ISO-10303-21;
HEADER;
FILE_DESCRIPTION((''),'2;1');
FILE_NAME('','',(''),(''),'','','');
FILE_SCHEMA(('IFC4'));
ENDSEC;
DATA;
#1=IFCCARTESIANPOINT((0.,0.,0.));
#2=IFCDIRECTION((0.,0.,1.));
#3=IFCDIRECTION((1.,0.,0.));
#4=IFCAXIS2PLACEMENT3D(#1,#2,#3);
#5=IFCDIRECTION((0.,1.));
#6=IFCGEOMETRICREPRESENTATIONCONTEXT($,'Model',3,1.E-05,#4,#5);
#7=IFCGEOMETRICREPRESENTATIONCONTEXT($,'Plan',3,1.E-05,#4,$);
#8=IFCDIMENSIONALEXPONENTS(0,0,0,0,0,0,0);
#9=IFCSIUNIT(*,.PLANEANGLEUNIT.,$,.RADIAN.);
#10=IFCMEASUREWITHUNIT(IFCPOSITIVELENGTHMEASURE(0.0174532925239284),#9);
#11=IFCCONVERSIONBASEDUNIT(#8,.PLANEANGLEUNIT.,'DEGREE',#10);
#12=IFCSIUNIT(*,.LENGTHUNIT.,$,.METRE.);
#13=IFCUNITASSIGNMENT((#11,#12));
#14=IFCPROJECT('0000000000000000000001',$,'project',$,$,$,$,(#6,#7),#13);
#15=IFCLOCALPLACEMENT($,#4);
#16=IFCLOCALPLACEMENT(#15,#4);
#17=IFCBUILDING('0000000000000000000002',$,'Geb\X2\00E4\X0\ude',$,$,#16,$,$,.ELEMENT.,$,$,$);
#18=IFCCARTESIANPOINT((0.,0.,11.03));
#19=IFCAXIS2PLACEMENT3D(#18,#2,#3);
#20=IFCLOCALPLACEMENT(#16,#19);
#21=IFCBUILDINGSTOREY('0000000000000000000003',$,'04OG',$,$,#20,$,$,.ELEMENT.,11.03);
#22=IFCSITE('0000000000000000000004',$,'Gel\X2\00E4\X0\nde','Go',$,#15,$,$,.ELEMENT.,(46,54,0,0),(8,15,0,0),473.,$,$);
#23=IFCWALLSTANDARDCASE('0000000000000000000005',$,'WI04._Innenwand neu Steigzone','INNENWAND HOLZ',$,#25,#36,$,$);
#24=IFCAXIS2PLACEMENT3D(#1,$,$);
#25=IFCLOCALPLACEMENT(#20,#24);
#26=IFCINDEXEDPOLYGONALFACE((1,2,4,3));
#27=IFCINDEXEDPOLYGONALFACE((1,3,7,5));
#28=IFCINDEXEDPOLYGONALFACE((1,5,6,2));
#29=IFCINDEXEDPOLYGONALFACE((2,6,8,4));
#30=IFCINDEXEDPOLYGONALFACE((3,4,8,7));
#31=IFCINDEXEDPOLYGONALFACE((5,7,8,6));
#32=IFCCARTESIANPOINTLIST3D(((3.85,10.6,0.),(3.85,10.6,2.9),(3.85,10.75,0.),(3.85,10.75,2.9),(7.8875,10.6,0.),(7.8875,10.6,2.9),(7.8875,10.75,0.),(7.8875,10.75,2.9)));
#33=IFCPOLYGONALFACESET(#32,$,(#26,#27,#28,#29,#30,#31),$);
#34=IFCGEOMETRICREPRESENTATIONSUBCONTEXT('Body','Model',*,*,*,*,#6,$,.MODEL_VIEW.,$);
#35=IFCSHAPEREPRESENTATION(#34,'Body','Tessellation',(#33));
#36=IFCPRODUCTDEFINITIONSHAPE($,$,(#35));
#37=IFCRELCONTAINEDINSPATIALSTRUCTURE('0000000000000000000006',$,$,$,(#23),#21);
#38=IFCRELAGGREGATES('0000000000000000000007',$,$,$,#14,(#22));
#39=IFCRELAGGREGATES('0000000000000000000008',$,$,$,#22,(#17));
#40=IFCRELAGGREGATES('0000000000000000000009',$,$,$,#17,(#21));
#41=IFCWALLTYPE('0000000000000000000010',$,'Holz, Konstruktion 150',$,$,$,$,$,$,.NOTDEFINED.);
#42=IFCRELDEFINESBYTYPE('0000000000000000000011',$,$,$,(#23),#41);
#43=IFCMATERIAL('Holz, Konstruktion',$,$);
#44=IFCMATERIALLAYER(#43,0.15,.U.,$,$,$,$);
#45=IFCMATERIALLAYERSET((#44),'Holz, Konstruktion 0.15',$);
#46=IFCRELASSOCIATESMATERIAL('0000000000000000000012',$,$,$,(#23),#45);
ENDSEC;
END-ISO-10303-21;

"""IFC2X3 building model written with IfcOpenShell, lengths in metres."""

from ifc_helpers import new_model, entity, si_unit, converted_unit, direction, frame, origin_with_axes, place, context, subcontext, project, spatial, polyline, outline, extrude, material, layer, layer_set, layer_usage, type_object, element, save


model = new_model("IFC2X3")

# Units and contexts
model_context = context("Model", 3, precision=1e-05, world=origin_with_axes(), true_north=direction((0.0, 1.0)))
plan_context = context("Plan", 3, precision=1e-05, world=origin_with_axes())
body_context = subcontext(model_context, "Body", "Model", "MODEL_VIEW")
ifc_project = project(units=[converted_unit("PLANEANGLEUNIT", "DEGREE", entity("IfcPositiveLengthMeasure", 0.0174532925239284), si_unit("PLANEANGLEUNIT", "RADIAN"), dimensions=[0, 0, 0, 0, 0, 0, 0]), si_unit("LENGTHUNIT", "METRE")], contexts=[model_context, plan_context])

# Site, building, storey
site_placement = place(None, origin_with_axes())
site = spatial("IfcSite", under=ifc_project, at=site_placement, Name="Gelände", Description="Go", CompositionType="ELEMENT", RefLatitude=(46, 54, 0, 0), RefLongitude=(8, 15, 0, 0), RefElevation=473.0)
building_placement = place(site_placement, origin_with_axes())
building = spatial("IfcBuilding", under=site, at=building_placement, Name="Gebäude", CompositionType="ELEMENT")
storey_placement = place(building_placement, frame((0.0, 0.0, 11.03), z_axis=(0.0, 0.0, 1.0), x_axis=(1.0, 0.0, 0.0)))
storey = spatial("IfcBuildingStorey", under=building, at=storey_placement, Name="04OG", CompositionType="ELEMENT", Elevation=11.03)

# Shared definitions
ifc_material_1 = material(Name="Holz, Konstruktion")

# Wall
ifc_layer_1 = layer(ifc_material_1, 0.15, ventilated="UNKNOWN")
ifc_layer_set_1 = layer_set([ifc_layer_1], Name="Holz, Konstruktion 0.15")
wall_type_1 = type_object("IfcWallType", Name="Holz, Konstruktion 150", PredefinedType="NOTDEFINED")
ifc_layer_usage_1 = layer_usage(ifc_layer_set_1, "AXIS2", "POSITIVE", 0.0)
wall_1_placement = place(storey_placement, frame((3.85, 10.6, 0.0), z_axis=(0.0, 0.0, 1.0), x_axis=(1.0, 0.0, 0.0)))
element("IfcWallStandardCase", 1, at=wall_1_placement, inside=storey, type_object=wall_type_1, material=ifc_layer_usage_1, Name="WI04._Innenwand neu Steigzone", Description="INNENWAND HOLZ", context=body_context, shape_type="SweptSolid", body=[
    extrude(outline(polyline([(0.0, 0.0), (4.0375, 0.0), (4.0375, 0.15), (0.0, 0.15), (0.0, 0.0)])), origin_with_axes(), (0.0, 0.0, 1.0), 2.9),
])

save(model, "model.ifc")
